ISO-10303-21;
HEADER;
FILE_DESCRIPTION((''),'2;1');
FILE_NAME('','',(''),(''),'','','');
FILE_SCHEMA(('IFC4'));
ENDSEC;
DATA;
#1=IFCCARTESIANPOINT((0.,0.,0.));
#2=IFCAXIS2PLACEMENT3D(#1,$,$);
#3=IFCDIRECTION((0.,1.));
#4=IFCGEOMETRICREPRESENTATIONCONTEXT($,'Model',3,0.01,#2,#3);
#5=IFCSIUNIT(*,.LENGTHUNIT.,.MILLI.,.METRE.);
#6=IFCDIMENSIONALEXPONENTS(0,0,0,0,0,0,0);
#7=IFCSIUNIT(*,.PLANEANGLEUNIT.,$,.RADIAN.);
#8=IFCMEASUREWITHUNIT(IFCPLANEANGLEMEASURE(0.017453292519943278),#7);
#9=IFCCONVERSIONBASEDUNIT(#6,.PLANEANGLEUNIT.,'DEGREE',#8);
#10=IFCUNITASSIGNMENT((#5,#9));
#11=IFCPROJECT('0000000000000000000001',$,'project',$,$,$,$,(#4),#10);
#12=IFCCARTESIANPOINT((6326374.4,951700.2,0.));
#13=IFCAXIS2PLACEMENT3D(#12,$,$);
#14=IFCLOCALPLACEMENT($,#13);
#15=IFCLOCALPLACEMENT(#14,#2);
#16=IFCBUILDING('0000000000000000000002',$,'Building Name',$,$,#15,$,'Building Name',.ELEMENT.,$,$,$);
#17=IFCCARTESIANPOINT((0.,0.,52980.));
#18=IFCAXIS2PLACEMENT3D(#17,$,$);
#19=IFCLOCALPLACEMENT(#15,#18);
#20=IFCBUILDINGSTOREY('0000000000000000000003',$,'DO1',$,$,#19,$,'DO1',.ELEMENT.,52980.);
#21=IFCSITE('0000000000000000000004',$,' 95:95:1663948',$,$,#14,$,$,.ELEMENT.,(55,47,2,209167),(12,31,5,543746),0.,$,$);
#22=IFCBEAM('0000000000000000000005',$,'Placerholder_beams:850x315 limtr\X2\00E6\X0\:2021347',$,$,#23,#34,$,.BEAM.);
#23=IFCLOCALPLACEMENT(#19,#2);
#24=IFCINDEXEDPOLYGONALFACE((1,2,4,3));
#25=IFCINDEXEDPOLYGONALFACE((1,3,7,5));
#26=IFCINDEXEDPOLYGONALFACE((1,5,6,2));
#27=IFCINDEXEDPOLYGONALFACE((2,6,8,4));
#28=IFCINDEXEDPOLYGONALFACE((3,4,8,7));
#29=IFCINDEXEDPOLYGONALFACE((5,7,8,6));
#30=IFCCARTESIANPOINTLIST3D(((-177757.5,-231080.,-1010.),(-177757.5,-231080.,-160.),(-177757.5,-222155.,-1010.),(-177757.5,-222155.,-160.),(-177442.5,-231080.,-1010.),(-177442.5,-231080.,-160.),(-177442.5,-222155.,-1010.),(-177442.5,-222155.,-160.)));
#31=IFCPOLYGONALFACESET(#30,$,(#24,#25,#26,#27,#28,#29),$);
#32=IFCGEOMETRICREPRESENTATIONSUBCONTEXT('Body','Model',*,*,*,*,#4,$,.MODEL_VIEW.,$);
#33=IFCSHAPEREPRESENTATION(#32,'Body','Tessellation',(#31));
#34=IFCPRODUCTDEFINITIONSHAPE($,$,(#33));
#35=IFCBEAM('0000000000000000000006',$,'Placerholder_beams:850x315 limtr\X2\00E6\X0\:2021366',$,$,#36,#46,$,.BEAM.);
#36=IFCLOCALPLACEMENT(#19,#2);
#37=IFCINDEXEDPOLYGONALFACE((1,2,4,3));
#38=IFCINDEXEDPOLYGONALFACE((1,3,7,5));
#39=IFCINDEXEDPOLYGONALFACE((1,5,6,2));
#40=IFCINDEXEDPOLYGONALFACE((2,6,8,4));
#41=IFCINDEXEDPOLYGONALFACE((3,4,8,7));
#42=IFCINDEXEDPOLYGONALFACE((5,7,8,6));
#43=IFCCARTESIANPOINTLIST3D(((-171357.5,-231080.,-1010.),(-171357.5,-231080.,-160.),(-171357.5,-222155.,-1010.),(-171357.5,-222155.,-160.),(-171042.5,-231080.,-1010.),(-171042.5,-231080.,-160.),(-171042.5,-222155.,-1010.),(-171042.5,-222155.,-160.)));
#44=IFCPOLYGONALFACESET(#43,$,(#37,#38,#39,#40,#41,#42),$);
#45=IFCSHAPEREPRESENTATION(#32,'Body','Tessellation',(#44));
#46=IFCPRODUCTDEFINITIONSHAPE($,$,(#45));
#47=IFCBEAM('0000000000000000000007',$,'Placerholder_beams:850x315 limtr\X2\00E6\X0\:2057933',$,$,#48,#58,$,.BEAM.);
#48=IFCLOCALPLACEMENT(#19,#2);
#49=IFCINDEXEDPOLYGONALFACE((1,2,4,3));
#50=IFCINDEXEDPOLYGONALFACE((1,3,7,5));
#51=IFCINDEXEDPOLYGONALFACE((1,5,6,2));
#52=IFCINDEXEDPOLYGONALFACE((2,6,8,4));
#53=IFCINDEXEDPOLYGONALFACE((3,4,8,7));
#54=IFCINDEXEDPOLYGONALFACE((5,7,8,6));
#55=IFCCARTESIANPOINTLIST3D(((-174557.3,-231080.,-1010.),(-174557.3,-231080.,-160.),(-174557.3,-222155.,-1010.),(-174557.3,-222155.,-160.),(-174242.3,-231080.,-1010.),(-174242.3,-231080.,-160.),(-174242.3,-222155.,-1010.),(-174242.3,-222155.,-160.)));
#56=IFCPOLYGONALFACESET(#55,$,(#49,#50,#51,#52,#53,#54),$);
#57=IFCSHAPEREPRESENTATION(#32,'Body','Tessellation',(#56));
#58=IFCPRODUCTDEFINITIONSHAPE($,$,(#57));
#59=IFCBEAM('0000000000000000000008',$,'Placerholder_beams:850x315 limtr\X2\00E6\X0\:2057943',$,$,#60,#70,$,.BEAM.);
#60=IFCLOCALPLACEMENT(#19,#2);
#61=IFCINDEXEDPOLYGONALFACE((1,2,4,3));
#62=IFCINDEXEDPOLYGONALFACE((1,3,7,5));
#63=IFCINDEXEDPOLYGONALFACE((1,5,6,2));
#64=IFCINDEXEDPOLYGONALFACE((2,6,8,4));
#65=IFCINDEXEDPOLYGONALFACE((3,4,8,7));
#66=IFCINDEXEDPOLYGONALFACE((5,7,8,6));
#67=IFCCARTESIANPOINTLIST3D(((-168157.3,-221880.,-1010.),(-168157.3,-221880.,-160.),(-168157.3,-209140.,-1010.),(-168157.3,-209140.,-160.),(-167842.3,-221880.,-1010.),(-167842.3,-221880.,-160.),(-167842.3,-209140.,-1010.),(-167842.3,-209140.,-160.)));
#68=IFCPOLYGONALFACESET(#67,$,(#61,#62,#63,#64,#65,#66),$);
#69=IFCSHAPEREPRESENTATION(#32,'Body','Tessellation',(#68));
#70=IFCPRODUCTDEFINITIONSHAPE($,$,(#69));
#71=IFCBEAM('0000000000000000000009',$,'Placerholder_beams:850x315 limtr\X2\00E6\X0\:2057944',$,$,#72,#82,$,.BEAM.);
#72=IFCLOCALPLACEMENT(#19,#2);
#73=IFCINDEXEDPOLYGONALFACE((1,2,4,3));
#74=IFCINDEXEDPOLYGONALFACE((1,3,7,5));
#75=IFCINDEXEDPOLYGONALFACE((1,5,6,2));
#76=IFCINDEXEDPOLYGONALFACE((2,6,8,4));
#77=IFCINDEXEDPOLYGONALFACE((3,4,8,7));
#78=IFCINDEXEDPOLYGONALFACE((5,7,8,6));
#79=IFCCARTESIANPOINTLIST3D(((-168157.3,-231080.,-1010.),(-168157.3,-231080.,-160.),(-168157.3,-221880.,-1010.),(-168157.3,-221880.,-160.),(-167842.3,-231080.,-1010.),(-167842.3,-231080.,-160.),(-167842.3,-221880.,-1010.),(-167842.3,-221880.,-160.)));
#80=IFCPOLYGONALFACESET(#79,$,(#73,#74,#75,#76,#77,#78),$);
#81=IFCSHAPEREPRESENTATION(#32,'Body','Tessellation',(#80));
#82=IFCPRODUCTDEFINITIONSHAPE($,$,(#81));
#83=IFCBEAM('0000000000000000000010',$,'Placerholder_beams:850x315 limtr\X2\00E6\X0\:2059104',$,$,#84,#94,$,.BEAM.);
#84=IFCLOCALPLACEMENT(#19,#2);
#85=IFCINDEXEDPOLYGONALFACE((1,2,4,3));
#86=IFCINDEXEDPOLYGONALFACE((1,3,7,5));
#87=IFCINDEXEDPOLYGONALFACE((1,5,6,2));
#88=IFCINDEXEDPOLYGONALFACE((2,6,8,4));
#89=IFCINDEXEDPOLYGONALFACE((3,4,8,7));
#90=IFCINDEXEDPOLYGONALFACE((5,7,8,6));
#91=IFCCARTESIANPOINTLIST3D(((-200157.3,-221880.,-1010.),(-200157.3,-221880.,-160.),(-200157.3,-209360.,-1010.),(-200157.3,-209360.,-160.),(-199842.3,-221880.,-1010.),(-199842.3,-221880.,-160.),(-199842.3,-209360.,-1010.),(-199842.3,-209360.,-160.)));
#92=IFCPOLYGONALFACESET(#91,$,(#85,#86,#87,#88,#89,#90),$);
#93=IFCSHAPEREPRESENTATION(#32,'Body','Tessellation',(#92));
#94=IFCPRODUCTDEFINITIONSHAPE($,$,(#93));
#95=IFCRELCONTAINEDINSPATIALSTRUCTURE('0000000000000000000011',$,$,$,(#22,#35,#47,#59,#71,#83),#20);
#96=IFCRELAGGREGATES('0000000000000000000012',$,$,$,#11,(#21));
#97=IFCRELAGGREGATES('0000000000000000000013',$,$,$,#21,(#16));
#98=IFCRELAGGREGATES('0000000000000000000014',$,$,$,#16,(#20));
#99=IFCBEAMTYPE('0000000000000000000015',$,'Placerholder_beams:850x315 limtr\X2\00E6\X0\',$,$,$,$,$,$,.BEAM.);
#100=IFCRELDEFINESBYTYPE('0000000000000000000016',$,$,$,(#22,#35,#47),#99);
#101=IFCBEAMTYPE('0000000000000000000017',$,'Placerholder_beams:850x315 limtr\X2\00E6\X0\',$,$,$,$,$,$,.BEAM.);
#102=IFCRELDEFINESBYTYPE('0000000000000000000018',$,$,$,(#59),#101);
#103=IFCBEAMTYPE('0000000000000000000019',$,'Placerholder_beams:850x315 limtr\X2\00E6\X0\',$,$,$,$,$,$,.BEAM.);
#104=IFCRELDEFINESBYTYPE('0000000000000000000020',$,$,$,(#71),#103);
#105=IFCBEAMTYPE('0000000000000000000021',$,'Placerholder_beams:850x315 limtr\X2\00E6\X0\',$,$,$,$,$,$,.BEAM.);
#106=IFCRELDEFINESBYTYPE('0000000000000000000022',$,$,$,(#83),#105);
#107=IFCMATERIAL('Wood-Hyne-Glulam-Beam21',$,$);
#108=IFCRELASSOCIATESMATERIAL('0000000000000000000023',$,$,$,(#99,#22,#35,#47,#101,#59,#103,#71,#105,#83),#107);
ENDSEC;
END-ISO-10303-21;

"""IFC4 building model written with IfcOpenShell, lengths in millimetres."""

from ifc_helpers import new_model, entity, si_unit, converted_unit, direction, frame, origin, place, context, subcontext, project, spatial, indexed_curve, outline, extrude, source, transform, mapped, material, type_object, type_shapes, element, save


model = new_model("IFC4")

# Units and contexts
model_context = context("Model", 3, precision=0.01, world=origin(), true_north=direction((0.0, 1.0)))
body_context = subcontext(model_context, "Body", "Model", "MODEL_VIEW")
ifc_project = project(units=[si_unit("LENGTHUNIT", "METRE", prefix="MILLI"), converted_unit("PLANEANGLEUNIT", "DEGREE", entity("IfcPlaneAngleMeasure", 0.017453292519943278), si_unit("PLANEANGLEUNIT", "RADIAN"), dimensions=[0, 0, 0, 0, 0, 0, 0])], contexts=[model_context])

# Site, building, storey
site_placement = place(None, frame((6326374.4, 951700.2, 0.0)))
site = spatial("IfcSite", under=ifc_project, at=site_placement, Name=" 95:95:1663948", CompositionType="ELEMENT", RefLatitude=(55, 47, 2, 209167), RefLongitude=(12, 31, 5, 543746), RefElevation=0.0)
building_placement = place(site_placement, origin())
building = spatial("IfcBuilding", under=site, at=building_placement, Name="Building Name", LongName="Building Name", CompositionType="ELEMENT")
storey_placement = place(building_placement, frame((0.0, 0.0, 52980.0)))
storey = spatial("IfcBuildingStorey", under=building, at=storey_placement, Name="DO1", LongName="DO1", CompositionType="ELEMENT", Elevation=52980.0)

# Beams
ifc_material = material(Name="Wood-Hyne-Glulam-Beam21")
beam_type_1 = type_object("IfcBeamType", Name="Placerholder_beams:850x315 limtræ", PredefinedType="BEAM", material=ifc_material)
shared_shape_1 = source(origin(), body_context, "Body", "SweptSolid", [
    extrude(outline(indexed_curve([(-4462.5, -157.5), (4462.5, -157.5), (4462.5, 157.5), (-4462.5, 157.5), (-4462.5, -157.5)], self_intersect=False)), frame((-137.5, 0.0, -425.0)), (0.0, 0.0, 1.0), 850.0),
])
type_shapes(beam_type_1, [shared_shape_1])
for number, where, z_axis, x_axis, name in (
    (1, (-177600.0, -226480.0, -585.0), (0.0, 0.0, 1.0), (0.0, 1.0, 0.0), "Placerholder_beams:850x315 limtræ:2021347"),
    (2, (-171200.0, -226480.0, -585.0), (0.0, 0.0, 1.0), (0.0, 1.0, 0.0), "Placerholder_beams:850x315 limtræ:2021366"),
    (3, (-174399.8, -226480.0, -585.0), (0.0, 0.0, 1.0), (0.0, 1.0, 0.0), "Placerholder_beams:850x315 limtræ:2057933"),
):
    element("IfcBeam", number, at=place(storey_placement, frame(where, z_axis=z_axis, x_axis=x_axis)), inside=storey, type_object=beam_type_1, material=ifc_material, Name=name, PredefinedType="BEAM", context=body_context, shape_type="MappedRepresentation", body=[
        mapped(shared_shape_1, transform((0.0, 0.0, 0.0), scale=1.0)),
    ])
beam_type_2 = type_object("IfcBeamType", Name="Placerholder_beams:850x315 limtræ", PredefinedType="BEAM", material=ifc_material)
shared_shape_2 = source(origin(), body_context, "Body", "SweptSolid", [
    extrude(outline(indexed_curve([(-6370.0, -157.5), (6370.0, -157.5), (6370.0, 157.5), (-6370.0, 157.5), (-6370.0, -157.5)], self_intersect=False)), frame((110.0, 0.0, -425.0)), (0.0, 0.0, 1.0), 850.0),
])
type_shapes(beam_type_2, [shared_shape_2])
beam_1_placement = place(storey_placement, frame((-167999.8, -215620.0, -585.0), z_axis=(0.0, 0.0, 1.0), x_axis=(0.0, 1.0, 0.0)))
element("IfcBeam", 4, at=beam_1_placement, inside=storey, type_object=beam_type_2, material=ifc_material, Name="Placerholder_beams:850x315 limtræ:2057943", PredefinedType="BEAM", context=body_context, shape_type="MappedRepresentation", body=[
    mapped(shared_shape_2, transform((0.0, 0.0, 0.0), scale=1.0)),
])
beam_type_3 = type_object("IfcBeamType", Name="Placerholder_beams:850x315 limtræ", PredefinedType="BEAM", material=ifc_material)
shared_shape_3 = source(origin(), body_context, "Body", "SweptSolid", [
    extrude(outline(indexed_curve([(-4600.0, -157.5), (4600.0, -157.5), (4600.0, 157.5), (-4600.0, 157.5), (-4600.0, -157.5)], self_intersect=False)), frame((0.0, 0.0, -425.0)), (0.0, 0.0, 1.0), 850.0),
])
type_shapes(beam_type_3, [shared_shape_3])
beam_2_placement = place(storey_placement, frame((-167999.8, -226480.0, -585.0), z_axis=(0.0, 0.0, 1.0), x_axis=(0.0, 1.0, 0.0)))
element("IfcBeam", 5, at=beam_2_placement, inside=storey, type_object=beam_type_3, material=ifc_material, Name="Placerholder_beams:850x315 limtræ:2057944", PredefinedType="BEAM", context=body_context, shape_type="MappedRepresentation", body=[
    mapped(shared_shape_3, transform((0.0, 0.0, 0.0), scale=1.0)),
])
beam_type_4 = type_object("IfcBeamType", Name="Placerholder_beams:850x315 limtræ", PredefinedType="BEAM", material=ifc_material)
shared_shape_4 = source(origin(), body_context, "Body", "SweptSolid", [
    extrude(outline(indexed_curve([(-6260.0, -157.5), (6260.0, -157.5), (6260.0, 157.5), (-6260.0, 157.5), (-6260.0, -157.5)], self_intersect=False)), frame((0.0, 0.0, -425.0)), (0.0, 0.0, 1.0), 850.0),
])
type_shapes(beam_type_4, [shared_shape_4])
beam_3_placement = place(storey_placement, frame((-199999.8, -215620.0, -585.0), z_axis=(0.0, 0.0, 1.0), x_axis=(0.0, 1.0, 0.0)))
element("IfcBeam", 6, at=beam_3_placement, inside=storey, type_object=beam_type_4, material=ifc_material, Name="Placerholder_beams:850x315 limtræ:2059104", PredefinedType="BEAM", context=body_context, shape_type="MappedRepresentation", body=[
    mapped(shared_shape_4, transform((0.0, 0.0, 0.0), scale=1.0)),
])

save(model, "model.ifc")
